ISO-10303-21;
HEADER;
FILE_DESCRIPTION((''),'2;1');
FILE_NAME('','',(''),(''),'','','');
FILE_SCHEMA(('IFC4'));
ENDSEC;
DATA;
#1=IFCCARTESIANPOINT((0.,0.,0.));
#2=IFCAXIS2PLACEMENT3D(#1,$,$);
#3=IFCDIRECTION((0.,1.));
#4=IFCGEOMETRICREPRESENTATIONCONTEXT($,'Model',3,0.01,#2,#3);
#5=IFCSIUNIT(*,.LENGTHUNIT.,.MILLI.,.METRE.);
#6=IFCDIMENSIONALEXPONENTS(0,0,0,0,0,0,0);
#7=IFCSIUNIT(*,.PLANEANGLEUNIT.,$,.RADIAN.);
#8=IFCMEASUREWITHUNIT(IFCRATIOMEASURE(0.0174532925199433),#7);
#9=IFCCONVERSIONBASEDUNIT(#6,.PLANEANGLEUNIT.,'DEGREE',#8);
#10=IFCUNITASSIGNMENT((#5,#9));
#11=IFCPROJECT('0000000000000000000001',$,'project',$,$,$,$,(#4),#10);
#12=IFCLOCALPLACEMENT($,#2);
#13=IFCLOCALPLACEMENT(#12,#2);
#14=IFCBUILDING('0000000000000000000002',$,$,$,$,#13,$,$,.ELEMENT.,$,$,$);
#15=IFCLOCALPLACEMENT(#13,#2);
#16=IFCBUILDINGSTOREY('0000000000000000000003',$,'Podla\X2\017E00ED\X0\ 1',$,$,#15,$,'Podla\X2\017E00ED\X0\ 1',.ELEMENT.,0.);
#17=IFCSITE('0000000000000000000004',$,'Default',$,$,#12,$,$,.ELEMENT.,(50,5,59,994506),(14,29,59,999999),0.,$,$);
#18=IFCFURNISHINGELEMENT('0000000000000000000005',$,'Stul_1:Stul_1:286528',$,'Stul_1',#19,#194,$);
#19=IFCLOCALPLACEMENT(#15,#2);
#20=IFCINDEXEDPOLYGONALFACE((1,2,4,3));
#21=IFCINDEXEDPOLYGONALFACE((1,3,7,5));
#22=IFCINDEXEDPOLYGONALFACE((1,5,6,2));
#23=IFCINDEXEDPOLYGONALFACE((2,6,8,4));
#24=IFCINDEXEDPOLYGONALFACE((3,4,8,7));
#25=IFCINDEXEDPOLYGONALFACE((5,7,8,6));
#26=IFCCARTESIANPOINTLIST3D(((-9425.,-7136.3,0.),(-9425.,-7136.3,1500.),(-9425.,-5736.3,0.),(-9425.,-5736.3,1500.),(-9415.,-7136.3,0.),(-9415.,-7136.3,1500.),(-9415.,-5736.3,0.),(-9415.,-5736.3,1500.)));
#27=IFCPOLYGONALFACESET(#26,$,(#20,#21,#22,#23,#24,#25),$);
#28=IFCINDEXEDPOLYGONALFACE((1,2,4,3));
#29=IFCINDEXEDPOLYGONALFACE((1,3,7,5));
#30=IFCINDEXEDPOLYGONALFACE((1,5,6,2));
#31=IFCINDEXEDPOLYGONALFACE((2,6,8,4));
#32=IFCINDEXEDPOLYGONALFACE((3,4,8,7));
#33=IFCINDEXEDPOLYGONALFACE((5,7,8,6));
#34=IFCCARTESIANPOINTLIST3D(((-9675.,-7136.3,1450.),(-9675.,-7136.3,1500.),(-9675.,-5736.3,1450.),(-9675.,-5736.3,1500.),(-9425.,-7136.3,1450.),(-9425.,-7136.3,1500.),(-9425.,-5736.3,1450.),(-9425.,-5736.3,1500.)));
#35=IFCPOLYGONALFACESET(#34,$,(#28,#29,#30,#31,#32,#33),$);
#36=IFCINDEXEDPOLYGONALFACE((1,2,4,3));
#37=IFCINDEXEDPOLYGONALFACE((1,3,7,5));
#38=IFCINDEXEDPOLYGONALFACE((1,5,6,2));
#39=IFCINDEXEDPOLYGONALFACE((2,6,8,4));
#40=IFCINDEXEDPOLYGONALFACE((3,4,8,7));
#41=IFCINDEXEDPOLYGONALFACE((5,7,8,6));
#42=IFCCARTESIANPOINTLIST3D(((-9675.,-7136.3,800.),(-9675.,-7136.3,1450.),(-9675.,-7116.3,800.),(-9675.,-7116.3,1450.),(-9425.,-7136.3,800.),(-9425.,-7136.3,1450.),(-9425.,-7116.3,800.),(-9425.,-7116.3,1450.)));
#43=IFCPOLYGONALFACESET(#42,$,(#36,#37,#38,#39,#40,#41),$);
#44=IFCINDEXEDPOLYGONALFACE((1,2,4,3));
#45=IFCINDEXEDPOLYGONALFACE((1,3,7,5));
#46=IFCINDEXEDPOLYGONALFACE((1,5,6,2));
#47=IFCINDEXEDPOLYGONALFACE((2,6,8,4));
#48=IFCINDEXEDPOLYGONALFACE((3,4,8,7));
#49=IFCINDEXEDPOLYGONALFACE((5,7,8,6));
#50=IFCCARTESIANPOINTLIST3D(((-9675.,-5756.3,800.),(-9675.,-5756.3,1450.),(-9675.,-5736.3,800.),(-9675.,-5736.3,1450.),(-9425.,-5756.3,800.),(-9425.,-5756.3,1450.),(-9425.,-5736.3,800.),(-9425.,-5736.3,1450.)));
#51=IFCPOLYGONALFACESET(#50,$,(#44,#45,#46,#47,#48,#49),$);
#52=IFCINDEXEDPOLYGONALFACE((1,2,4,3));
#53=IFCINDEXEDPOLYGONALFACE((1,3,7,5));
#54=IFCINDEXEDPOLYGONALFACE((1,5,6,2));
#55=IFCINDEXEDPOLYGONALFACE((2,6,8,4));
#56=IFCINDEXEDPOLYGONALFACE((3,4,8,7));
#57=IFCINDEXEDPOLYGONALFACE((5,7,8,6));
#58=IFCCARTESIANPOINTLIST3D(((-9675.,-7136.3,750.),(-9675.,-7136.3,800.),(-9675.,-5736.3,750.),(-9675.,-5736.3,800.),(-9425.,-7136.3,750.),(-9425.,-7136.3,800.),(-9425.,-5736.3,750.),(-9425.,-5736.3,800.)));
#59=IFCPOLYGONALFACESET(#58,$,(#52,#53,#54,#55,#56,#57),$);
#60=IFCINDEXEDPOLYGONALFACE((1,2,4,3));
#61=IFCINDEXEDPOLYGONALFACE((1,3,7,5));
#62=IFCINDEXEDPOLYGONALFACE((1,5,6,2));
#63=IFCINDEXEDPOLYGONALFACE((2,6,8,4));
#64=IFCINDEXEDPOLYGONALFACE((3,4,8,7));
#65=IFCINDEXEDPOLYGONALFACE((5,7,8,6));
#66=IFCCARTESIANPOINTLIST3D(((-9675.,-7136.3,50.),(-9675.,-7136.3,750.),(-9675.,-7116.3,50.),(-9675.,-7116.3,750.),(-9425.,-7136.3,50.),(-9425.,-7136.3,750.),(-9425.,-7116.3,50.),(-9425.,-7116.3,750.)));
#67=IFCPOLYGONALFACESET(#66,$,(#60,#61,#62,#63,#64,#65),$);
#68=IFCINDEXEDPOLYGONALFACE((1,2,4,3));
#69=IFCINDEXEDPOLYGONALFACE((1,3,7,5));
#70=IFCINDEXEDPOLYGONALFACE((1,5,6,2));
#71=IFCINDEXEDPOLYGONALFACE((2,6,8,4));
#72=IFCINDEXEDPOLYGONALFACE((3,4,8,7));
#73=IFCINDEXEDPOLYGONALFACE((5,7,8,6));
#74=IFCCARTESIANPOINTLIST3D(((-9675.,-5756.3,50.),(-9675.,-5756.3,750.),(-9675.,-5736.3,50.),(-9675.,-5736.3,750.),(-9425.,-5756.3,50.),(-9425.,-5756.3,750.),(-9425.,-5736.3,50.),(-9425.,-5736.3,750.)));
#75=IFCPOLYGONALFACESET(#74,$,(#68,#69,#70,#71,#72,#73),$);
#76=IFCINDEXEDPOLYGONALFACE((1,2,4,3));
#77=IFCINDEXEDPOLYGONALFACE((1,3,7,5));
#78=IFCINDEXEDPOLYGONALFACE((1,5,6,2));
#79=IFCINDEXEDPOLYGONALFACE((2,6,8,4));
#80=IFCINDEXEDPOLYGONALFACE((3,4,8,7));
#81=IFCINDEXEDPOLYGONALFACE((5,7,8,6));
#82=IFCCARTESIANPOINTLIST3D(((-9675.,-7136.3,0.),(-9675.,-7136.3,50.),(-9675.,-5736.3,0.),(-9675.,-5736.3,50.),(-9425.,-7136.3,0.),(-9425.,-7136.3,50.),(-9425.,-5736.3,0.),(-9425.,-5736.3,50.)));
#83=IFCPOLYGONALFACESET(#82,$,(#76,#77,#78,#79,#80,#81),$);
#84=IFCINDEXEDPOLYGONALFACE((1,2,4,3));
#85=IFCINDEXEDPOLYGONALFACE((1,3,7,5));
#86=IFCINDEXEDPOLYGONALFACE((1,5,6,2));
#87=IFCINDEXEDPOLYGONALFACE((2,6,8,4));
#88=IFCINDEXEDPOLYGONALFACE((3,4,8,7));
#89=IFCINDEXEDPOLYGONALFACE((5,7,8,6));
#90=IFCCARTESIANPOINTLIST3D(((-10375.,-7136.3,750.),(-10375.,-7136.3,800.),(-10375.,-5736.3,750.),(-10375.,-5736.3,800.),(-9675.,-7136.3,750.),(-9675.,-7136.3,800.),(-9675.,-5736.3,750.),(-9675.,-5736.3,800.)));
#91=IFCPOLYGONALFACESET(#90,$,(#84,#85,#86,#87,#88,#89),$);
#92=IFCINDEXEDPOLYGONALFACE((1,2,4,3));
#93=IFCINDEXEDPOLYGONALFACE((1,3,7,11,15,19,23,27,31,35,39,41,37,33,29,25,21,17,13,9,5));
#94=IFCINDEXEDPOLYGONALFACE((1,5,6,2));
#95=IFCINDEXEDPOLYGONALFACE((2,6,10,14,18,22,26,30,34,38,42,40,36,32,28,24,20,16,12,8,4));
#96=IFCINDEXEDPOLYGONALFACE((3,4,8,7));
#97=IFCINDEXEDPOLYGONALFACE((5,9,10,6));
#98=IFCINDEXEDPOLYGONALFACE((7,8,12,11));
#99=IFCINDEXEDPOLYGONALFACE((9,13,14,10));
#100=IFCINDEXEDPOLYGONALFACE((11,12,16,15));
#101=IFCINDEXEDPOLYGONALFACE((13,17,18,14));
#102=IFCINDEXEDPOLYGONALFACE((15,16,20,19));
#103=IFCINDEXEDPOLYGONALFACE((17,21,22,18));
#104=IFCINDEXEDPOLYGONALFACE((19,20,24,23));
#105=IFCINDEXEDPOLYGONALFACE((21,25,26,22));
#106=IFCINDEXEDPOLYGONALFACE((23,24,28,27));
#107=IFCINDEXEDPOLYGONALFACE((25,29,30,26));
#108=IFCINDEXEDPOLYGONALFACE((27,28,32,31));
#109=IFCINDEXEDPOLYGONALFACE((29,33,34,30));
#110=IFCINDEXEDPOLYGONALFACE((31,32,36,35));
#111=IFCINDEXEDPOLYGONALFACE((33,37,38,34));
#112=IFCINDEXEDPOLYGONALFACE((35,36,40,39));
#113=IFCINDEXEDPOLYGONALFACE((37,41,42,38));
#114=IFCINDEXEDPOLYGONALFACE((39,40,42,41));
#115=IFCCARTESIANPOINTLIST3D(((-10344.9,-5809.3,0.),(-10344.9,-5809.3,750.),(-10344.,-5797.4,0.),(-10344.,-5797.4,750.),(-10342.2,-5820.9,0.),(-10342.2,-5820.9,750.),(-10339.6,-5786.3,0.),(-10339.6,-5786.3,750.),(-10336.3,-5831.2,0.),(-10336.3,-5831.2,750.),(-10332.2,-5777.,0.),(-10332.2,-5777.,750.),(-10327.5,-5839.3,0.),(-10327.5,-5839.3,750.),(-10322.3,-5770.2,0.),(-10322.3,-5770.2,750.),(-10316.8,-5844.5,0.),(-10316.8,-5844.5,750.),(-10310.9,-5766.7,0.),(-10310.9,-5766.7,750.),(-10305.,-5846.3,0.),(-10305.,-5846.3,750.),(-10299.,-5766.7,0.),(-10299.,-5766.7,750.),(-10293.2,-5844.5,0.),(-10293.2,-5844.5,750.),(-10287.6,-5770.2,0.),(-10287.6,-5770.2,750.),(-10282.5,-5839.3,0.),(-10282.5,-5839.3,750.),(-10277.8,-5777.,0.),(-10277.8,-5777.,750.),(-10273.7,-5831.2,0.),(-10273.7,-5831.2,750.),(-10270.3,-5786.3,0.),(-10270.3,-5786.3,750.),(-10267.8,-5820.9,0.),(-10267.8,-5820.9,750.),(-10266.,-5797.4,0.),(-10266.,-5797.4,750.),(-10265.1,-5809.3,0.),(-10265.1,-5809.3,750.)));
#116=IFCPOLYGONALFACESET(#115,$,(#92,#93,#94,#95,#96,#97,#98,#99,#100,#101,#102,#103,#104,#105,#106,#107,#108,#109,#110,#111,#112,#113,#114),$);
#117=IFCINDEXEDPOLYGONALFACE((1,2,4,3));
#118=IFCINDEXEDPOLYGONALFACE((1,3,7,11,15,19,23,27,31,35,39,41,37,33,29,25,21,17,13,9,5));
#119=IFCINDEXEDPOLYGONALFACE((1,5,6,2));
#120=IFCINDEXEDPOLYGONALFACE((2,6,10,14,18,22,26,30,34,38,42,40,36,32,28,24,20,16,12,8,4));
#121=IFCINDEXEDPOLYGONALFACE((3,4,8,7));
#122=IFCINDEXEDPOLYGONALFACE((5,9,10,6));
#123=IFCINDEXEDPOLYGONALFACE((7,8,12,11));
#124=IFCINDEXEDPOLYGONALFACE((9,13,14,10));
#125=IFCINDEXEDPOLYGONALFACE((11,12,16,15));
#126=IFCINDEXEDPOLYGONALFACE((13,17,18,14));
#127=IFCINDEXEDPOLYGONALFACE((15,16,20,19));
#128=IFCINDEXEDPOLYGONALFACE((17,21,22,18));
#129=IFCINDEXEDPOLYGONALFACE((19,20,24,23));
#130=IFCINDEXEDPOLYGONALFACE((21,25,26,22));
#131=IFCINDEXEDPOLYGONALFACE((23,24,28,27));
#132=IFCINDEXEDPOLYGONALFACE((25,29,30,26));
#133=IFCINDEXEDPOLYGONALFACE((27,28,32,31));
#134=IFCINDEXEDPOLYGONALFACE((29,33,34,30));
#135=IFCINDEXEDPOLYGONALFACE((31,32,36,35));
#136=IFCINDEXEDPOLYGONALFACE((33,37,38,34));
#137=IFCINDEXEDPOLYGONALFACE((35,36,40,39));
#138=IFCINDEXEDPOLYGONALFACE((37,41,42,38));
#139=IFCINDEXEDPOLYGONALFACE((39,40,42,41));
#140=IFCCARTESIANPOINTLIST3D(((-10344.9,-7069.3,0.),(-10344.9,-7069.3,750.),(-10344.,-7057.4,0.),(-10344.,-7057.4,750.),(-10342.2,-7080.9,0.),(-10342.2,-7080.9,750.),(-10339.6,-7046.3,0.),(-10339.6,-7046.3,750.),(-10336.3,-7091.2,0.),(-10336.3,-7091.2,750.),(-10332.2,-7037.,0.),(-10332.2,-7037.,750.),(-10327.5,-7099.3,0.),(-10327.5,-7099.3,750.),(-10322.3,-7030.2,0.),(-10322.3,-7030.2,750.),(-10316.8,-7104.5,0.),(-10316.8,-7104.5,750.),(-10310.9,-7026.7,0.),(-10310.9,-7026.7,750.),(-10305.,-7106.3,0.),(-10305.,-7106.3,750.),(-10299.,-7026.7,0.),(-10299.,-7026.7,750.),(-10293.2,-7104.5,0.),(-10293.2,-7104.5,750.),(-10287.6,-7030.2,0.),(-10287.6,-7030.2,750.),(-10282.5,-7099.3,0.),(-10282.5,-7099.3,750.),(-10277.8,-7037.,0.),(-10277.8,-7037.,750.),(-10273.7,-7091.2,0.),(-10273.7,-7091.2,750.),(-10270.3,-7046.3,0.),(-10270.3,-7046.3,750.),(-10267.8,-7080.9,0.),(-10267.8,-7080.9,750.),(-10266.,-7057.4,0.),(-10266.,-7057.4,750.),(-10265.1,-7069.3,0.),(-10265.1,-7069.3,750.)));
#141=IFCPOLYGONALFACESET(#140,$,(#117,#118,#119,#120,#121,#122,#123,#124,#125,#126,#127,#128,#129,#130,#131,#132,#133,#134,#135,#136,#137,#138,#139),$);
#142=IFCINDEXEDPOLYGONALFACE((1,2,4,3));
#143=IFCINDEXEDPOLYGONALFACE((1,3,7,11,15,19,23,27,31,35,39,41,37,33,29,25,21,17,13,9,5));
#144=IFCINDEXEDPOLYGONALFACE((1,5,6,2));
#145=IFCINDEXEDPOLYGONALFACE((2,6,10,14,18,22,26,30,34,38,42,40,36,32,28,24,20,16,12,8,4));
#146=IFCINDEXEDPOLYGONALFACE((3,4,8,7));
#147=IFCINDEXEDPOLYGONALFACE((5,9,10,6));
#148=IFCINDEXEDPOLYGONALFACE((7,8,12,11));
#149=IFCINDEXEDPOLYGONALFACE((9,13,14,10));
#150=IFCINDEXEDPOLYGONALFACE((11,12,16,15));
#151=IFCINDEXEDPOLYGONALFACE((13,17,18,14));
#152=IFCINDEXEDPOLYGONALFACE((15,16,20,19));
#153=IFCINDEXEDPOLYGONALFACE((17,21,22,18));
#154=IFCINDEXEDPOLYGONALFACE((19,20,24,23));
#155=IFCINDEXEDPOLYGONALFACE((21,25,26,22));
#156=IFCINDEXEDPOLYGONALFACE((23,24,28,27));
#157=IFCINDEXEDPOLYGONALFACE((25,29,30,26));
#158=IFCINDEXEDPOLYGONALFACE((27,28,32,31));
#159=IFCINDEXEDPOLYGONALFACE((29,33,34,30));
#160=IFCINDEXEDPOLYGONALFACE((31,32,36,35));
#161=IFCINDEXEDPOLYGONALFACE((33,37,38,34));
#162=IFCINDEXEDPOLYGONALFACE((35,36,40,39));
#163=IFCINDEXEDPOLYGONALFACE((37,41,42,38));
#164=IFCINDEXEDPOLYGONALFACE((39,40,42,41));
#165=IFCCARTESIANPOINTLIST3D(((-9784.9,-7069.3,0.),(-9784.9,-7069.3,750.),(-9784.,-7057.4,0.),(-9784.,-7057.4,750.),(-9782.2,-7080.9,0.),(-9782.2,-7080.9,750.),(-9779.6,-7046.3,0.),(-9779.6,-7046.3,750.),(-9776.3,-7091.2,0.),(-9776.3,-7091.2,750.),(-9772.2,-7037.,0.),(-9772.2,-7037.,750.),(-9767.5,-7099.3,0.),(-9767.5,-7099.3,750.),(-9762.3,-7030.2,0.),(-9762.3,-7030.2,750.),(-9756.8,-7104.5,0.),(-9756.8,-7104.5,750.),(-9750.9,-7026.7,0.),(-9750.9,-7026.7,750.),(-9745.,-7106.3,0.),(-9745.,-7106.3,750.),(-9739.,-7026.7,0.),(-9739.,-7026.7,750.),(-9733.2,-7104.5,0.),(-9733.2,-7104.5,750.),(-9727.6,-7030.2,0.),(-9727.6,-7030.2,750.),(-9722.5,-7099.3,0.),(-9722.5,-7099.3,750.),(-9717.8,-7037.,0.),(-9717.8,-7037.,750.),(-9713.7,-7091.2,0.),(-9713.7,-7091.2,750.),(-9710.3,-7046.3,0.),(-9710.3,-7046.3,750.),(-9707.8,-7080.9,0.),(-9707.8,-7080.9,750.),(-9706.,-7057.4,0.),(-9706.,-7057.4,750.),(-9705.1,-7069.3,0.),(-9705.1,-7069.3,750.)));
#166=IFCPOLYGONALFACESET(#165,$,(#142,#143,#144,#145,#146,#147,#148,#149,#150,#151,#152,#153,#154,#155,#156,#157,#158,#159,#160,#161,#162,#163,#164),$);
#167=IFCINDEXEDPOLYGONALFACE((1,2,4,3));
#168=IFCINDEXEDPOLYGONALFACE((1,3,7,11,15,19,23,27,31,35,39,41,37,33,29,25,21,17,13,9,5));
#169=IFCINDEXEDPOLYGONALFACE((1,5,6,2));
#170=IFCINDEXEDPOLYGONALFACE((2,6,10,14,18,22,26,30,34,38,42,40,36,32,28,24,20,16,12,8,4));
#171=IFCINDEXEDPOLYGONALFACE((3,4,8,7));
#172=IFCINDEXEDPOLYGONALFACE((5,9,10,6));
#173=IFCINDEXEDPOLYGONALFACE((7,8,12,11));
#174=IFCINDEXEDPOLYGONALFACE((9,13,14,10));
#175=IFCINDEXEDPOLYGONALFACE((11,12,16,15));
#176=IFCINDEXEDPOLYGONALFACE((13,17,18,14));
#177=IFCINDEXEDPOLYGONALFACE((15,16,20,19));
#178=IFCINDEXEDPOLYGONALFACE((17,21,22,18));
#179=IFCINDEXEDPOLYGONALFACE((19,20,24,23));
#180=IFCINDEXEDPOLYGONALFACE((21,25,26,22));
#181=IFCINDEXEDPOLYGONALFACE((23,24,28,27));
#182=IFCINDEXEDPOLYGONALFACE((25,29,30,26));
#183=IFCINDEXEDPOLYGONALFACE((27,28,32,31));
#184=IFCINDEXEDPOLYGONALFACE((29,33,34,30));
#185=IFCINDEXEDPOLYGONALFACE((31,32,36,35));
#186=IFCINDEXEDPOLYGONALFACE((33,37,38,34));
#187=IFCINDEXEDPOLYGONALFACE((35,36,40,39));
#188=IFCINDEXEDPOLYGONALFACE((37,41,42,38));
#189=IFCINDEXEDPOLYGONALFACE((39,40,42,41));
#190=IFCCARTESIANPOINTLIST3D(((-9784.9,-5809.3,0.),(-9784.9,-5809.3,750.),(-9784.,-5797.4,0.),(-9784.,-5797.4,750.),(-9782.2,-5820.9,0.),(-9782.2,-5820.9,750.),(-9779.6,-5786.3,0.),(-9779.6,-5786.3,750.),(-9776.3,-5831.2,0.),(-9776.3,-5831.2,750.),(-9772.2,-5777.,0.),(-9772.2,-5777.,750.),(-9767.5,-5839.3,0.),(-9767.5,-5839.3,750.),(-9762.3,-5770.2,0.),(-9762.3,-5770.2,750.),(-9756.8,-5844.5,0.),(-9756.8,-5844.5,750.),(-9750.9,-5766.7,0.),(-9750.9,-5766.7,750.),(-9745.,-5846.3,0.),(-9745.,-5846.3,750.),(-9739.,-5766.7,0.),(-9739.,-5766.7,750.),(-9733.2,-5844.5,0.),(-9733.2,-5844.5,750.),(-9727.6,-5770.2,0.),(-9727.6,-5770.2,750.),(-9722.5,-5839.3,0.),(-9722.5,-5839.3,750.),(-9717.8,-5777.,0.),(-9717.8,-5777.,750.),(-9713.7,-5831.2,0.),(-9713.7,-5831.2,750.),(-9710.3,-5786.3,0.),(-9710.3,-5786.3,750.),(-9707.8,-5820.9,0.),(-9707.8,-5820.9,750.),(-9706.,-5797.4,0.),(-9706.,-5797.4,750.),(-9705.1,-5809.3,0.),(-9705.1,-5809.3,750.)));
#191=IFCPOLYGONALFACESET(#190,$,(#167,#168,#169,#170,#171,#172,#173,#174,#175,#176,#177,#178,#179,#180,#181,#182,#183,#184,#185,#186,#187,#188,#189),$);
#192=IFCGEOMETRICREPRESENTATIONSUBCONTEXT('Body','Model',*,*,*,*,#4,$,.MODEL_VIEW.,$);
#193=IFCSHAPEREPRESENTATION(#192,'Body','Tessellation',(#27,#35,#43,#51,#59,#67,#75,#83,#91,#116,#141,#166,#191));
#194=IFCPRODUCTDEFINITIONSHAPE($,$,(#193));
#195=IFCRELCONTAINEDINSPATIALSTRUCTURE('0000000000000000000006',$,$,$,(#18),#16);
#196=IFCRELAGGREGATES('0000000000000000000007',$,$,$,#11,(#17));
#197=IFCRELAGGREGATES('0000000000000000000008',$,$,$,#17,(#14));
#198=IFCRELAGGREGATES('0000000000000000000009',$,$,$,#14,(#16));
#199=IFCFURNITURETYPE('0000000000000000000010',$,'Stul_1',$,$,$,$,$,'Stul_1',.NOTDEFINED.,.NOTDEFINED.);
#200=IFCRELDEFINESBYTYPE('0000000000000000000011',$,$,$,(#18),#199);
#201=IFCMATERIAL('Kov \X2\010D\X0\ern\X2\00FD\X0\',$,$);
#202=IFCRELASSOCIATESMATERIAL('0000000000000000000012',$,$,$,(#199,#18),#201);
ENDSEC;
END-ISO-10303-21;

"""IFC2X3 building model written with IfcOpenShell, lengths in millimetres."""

from ifc_helpers import new_model, entity, si_unit, converted_unit, direction, frame, frame_2d, origin, origin_2d_with_axis, place, context, subcontext, project, spatial, rectangle, circle, extrude, source, transform, mapped, material, type_object, type_shapes, element, save


model = new_model("IFC2X3")

# Units and contexts
model_context = context("Model", 3, precision=0.01, world=origin(), true_north=direction((0.0, 1.0)))
body_context = subcontext(model_context, "Body", "Model", "MODEL_VIEW")
ifc_project = project(units=[si_unit("LENGTHUNIT", "METRE", prefix="MILLI"), converted_unit("PLANEANGLEUNIT", "DEGREE", entity("IfcRatioMeasure", 0.0174532925199433), si_unit("PLANEANGLEUNIT", "RADIAN"), dimensions=[0, 0, 0, 0, 0, 0, 0])], contexts=[model_context])

# Site, building, storey
site_placement = place(None, origin())
site = spatial("IfcSite", under=ifc_project, at=site_placement, Name="Default", CompositionType="ELEMENT", RefLatitude=(50, 5, 59, 994506), RefLongitude=(14, 29, 59, 999999), RefElevation=0.0)
building_placement = place(site_placement, origin())
building = spatial("IfcBuilding", under=site, at=building_placement, CompositionType="ELEMENT")
storey_placement = place(building_placement, origin())
storey = spatial("IfcBuildingStorey", under=building, at=storey_placement, Name="Podlaží 1", LongName="Podlaží 1", CompositionType="ELEMENT", Elevation=0.0)

# Furnishing element
ifc_material_1 = material(Name="Kov černý")
furniture_type = type_object("IfcFurnitureType", Name="Stul_1", ElementType="Stul_1", material=ifc_material_1)
shared_shape_1 = source(origin(), body_context, "Body", "SweptSolid", [
    extrude(rectangle(XDim=1400.0, YDim=10.0, at=origin_2d_with_axis()), frame((0.0, 605.0, 0.0), z_axis=(0.0, 0.0, 1.0), x_axis=(-1.0, 0.0, 0.0)), (0.0, 0.0, 1.0), 1500.0),
    extrude(rectangle(XDim=1400.0, YDim=250.0, at=frame_2d((0.0, 0.0), x_axis=(1.0, 0.0))), frame((0.0, 475.0, 1450.0), z_axis=(0.0, 0.0, 1.0), x_axis=(-1.0, 0.0, 0.0)), (0.0, 0.0, 1.0), 50.0),
    extrude(rectangle(XDim=20.0, YDim=250.0, at=origin_2d_with_axis()), frame((690.0, 475.0, 800.0), z_axis=(0.0, 0.0, 1.0), x_axis=(-1.0, 0.0, 0.0)), (0.0, 0.0, 1.0), 650.0),
    extrude(rectangle(XDim=20.0, YDim=250.0, at=frame_2d((0.0, 0.0), x_axis=(1.0, 0.0))), frame((-690.0, 475.0, 800.0), z_axis=(0.0, 0.0, 1.0), x_axis=(-1.0, 0.0, 0.0)), (0.0, 0.0, 1.0), 650.0),
    extrude(rectangle(XDim=1400.0, YDim=250.0, at=origin_2d_with_axis()), frame((0.0, 475.0, 750.0), z_axis=(0.0, 0.0, 1.0), x_axis=(-1.0, 0.0, 0.0)), (0.0, 0.0, 1.0), 50.0),
    extrude(rectangle(XDim=20.0, YDim=250.0, at=origin_2d_with_axis()), frame((690.0, 475.0, 50.0), z_axis=(0.0, 0.0, 1.0), x_axis=(-1.0, 0.0, 0.0)), (0.0, 0.0, 1.0), 700.0),
    extrude(rectangle(XDim=20.0, YDim=250.0, at=frame_2d((0.0, 0.0), x_axis=(1.0, 0.0))), frame((-690.0, 475.0, 50.0), z_axis=(0.0, 0.0, 1.0), x_axis=(-1.0, 0.0, 0.0)), (0.0, 0.0, 1.0), 700.0),
    extrude(rectangle(XDim=1400.0, YDim=250.0, at=origin_2d_with_axis()), frame((0.0, 475.0, 0.0), z_axis=(0.0, 0.0, 1.0), x_axis=(-1.0, 0.0, 0.0)), (0.0, 0.0, 1.0), 50.0),
    extrude(rectangle(XDim=1400.0, YDim=700.0, at=origin_2d_with_axis()), frame((0.0, 0.0, 750.0), z_axis=(0.0, 0.0, 1.0), x_axis=(-1.0, 0.0, 0.0)), (0.0, 0.0, 1.0), 50.0),
    extrude(circle(Radius=40.0, at=frame_2d((0.0, 0.0), x_axis=(1.0, 0.0))), frame((-630.0, -280.0, 0.0)), (0.0, 0.0, 1.0), 750.0),
    extrude(circle(Radius=40.0, at=frame_2d((0.0, 0.0), x_axis=(1.0, 0.0))), frame((630.0, -280.0, 0.0)), (0.0, 0.0, 1.0), 750.0),
    extrude(circle(Radius=40.0, at=frame_2d((0.0, 0.0), x_axis=(1.0, 0.0))), frame((630.0, 280.0, 0.0)), (0.0, 0.0, 1.0), 750.0),
    extrude(circle(Radius=40.0, at=frame_2d((0.0, 0.0), x_axis=(1.0, 0.0))), frame((-630.0, 280.0, 0.0)), (0.0, 0.0, 1.0), 750.0),
])
type_shapes(furniture_type, [shared_shape_1])
for number, where, z_axis, x_axis, name in (
    (1, (-10025.0, -6436.3, 0.0), (0.0, 0.0, 1.0), (0.0, -1.0, 0.0), "Stul_1:Stul_1:286528"),
):
    element("IfcFurnishingElement", number, at=place(storey_placement, frame(where, z_axis=z_axis, x_axis=x_axis)), inside=storey, type_object=furniture_type, material=ifc_material_1, Name=name, ObjectType="Stul_1", context=body_context, shape_type="MappedRepresentation", body=[
        mapped(shared_shape_1, transform((0.0, 0.0, 0.0), scale=1.0)),
    ])

save(model, "model.ifc")
